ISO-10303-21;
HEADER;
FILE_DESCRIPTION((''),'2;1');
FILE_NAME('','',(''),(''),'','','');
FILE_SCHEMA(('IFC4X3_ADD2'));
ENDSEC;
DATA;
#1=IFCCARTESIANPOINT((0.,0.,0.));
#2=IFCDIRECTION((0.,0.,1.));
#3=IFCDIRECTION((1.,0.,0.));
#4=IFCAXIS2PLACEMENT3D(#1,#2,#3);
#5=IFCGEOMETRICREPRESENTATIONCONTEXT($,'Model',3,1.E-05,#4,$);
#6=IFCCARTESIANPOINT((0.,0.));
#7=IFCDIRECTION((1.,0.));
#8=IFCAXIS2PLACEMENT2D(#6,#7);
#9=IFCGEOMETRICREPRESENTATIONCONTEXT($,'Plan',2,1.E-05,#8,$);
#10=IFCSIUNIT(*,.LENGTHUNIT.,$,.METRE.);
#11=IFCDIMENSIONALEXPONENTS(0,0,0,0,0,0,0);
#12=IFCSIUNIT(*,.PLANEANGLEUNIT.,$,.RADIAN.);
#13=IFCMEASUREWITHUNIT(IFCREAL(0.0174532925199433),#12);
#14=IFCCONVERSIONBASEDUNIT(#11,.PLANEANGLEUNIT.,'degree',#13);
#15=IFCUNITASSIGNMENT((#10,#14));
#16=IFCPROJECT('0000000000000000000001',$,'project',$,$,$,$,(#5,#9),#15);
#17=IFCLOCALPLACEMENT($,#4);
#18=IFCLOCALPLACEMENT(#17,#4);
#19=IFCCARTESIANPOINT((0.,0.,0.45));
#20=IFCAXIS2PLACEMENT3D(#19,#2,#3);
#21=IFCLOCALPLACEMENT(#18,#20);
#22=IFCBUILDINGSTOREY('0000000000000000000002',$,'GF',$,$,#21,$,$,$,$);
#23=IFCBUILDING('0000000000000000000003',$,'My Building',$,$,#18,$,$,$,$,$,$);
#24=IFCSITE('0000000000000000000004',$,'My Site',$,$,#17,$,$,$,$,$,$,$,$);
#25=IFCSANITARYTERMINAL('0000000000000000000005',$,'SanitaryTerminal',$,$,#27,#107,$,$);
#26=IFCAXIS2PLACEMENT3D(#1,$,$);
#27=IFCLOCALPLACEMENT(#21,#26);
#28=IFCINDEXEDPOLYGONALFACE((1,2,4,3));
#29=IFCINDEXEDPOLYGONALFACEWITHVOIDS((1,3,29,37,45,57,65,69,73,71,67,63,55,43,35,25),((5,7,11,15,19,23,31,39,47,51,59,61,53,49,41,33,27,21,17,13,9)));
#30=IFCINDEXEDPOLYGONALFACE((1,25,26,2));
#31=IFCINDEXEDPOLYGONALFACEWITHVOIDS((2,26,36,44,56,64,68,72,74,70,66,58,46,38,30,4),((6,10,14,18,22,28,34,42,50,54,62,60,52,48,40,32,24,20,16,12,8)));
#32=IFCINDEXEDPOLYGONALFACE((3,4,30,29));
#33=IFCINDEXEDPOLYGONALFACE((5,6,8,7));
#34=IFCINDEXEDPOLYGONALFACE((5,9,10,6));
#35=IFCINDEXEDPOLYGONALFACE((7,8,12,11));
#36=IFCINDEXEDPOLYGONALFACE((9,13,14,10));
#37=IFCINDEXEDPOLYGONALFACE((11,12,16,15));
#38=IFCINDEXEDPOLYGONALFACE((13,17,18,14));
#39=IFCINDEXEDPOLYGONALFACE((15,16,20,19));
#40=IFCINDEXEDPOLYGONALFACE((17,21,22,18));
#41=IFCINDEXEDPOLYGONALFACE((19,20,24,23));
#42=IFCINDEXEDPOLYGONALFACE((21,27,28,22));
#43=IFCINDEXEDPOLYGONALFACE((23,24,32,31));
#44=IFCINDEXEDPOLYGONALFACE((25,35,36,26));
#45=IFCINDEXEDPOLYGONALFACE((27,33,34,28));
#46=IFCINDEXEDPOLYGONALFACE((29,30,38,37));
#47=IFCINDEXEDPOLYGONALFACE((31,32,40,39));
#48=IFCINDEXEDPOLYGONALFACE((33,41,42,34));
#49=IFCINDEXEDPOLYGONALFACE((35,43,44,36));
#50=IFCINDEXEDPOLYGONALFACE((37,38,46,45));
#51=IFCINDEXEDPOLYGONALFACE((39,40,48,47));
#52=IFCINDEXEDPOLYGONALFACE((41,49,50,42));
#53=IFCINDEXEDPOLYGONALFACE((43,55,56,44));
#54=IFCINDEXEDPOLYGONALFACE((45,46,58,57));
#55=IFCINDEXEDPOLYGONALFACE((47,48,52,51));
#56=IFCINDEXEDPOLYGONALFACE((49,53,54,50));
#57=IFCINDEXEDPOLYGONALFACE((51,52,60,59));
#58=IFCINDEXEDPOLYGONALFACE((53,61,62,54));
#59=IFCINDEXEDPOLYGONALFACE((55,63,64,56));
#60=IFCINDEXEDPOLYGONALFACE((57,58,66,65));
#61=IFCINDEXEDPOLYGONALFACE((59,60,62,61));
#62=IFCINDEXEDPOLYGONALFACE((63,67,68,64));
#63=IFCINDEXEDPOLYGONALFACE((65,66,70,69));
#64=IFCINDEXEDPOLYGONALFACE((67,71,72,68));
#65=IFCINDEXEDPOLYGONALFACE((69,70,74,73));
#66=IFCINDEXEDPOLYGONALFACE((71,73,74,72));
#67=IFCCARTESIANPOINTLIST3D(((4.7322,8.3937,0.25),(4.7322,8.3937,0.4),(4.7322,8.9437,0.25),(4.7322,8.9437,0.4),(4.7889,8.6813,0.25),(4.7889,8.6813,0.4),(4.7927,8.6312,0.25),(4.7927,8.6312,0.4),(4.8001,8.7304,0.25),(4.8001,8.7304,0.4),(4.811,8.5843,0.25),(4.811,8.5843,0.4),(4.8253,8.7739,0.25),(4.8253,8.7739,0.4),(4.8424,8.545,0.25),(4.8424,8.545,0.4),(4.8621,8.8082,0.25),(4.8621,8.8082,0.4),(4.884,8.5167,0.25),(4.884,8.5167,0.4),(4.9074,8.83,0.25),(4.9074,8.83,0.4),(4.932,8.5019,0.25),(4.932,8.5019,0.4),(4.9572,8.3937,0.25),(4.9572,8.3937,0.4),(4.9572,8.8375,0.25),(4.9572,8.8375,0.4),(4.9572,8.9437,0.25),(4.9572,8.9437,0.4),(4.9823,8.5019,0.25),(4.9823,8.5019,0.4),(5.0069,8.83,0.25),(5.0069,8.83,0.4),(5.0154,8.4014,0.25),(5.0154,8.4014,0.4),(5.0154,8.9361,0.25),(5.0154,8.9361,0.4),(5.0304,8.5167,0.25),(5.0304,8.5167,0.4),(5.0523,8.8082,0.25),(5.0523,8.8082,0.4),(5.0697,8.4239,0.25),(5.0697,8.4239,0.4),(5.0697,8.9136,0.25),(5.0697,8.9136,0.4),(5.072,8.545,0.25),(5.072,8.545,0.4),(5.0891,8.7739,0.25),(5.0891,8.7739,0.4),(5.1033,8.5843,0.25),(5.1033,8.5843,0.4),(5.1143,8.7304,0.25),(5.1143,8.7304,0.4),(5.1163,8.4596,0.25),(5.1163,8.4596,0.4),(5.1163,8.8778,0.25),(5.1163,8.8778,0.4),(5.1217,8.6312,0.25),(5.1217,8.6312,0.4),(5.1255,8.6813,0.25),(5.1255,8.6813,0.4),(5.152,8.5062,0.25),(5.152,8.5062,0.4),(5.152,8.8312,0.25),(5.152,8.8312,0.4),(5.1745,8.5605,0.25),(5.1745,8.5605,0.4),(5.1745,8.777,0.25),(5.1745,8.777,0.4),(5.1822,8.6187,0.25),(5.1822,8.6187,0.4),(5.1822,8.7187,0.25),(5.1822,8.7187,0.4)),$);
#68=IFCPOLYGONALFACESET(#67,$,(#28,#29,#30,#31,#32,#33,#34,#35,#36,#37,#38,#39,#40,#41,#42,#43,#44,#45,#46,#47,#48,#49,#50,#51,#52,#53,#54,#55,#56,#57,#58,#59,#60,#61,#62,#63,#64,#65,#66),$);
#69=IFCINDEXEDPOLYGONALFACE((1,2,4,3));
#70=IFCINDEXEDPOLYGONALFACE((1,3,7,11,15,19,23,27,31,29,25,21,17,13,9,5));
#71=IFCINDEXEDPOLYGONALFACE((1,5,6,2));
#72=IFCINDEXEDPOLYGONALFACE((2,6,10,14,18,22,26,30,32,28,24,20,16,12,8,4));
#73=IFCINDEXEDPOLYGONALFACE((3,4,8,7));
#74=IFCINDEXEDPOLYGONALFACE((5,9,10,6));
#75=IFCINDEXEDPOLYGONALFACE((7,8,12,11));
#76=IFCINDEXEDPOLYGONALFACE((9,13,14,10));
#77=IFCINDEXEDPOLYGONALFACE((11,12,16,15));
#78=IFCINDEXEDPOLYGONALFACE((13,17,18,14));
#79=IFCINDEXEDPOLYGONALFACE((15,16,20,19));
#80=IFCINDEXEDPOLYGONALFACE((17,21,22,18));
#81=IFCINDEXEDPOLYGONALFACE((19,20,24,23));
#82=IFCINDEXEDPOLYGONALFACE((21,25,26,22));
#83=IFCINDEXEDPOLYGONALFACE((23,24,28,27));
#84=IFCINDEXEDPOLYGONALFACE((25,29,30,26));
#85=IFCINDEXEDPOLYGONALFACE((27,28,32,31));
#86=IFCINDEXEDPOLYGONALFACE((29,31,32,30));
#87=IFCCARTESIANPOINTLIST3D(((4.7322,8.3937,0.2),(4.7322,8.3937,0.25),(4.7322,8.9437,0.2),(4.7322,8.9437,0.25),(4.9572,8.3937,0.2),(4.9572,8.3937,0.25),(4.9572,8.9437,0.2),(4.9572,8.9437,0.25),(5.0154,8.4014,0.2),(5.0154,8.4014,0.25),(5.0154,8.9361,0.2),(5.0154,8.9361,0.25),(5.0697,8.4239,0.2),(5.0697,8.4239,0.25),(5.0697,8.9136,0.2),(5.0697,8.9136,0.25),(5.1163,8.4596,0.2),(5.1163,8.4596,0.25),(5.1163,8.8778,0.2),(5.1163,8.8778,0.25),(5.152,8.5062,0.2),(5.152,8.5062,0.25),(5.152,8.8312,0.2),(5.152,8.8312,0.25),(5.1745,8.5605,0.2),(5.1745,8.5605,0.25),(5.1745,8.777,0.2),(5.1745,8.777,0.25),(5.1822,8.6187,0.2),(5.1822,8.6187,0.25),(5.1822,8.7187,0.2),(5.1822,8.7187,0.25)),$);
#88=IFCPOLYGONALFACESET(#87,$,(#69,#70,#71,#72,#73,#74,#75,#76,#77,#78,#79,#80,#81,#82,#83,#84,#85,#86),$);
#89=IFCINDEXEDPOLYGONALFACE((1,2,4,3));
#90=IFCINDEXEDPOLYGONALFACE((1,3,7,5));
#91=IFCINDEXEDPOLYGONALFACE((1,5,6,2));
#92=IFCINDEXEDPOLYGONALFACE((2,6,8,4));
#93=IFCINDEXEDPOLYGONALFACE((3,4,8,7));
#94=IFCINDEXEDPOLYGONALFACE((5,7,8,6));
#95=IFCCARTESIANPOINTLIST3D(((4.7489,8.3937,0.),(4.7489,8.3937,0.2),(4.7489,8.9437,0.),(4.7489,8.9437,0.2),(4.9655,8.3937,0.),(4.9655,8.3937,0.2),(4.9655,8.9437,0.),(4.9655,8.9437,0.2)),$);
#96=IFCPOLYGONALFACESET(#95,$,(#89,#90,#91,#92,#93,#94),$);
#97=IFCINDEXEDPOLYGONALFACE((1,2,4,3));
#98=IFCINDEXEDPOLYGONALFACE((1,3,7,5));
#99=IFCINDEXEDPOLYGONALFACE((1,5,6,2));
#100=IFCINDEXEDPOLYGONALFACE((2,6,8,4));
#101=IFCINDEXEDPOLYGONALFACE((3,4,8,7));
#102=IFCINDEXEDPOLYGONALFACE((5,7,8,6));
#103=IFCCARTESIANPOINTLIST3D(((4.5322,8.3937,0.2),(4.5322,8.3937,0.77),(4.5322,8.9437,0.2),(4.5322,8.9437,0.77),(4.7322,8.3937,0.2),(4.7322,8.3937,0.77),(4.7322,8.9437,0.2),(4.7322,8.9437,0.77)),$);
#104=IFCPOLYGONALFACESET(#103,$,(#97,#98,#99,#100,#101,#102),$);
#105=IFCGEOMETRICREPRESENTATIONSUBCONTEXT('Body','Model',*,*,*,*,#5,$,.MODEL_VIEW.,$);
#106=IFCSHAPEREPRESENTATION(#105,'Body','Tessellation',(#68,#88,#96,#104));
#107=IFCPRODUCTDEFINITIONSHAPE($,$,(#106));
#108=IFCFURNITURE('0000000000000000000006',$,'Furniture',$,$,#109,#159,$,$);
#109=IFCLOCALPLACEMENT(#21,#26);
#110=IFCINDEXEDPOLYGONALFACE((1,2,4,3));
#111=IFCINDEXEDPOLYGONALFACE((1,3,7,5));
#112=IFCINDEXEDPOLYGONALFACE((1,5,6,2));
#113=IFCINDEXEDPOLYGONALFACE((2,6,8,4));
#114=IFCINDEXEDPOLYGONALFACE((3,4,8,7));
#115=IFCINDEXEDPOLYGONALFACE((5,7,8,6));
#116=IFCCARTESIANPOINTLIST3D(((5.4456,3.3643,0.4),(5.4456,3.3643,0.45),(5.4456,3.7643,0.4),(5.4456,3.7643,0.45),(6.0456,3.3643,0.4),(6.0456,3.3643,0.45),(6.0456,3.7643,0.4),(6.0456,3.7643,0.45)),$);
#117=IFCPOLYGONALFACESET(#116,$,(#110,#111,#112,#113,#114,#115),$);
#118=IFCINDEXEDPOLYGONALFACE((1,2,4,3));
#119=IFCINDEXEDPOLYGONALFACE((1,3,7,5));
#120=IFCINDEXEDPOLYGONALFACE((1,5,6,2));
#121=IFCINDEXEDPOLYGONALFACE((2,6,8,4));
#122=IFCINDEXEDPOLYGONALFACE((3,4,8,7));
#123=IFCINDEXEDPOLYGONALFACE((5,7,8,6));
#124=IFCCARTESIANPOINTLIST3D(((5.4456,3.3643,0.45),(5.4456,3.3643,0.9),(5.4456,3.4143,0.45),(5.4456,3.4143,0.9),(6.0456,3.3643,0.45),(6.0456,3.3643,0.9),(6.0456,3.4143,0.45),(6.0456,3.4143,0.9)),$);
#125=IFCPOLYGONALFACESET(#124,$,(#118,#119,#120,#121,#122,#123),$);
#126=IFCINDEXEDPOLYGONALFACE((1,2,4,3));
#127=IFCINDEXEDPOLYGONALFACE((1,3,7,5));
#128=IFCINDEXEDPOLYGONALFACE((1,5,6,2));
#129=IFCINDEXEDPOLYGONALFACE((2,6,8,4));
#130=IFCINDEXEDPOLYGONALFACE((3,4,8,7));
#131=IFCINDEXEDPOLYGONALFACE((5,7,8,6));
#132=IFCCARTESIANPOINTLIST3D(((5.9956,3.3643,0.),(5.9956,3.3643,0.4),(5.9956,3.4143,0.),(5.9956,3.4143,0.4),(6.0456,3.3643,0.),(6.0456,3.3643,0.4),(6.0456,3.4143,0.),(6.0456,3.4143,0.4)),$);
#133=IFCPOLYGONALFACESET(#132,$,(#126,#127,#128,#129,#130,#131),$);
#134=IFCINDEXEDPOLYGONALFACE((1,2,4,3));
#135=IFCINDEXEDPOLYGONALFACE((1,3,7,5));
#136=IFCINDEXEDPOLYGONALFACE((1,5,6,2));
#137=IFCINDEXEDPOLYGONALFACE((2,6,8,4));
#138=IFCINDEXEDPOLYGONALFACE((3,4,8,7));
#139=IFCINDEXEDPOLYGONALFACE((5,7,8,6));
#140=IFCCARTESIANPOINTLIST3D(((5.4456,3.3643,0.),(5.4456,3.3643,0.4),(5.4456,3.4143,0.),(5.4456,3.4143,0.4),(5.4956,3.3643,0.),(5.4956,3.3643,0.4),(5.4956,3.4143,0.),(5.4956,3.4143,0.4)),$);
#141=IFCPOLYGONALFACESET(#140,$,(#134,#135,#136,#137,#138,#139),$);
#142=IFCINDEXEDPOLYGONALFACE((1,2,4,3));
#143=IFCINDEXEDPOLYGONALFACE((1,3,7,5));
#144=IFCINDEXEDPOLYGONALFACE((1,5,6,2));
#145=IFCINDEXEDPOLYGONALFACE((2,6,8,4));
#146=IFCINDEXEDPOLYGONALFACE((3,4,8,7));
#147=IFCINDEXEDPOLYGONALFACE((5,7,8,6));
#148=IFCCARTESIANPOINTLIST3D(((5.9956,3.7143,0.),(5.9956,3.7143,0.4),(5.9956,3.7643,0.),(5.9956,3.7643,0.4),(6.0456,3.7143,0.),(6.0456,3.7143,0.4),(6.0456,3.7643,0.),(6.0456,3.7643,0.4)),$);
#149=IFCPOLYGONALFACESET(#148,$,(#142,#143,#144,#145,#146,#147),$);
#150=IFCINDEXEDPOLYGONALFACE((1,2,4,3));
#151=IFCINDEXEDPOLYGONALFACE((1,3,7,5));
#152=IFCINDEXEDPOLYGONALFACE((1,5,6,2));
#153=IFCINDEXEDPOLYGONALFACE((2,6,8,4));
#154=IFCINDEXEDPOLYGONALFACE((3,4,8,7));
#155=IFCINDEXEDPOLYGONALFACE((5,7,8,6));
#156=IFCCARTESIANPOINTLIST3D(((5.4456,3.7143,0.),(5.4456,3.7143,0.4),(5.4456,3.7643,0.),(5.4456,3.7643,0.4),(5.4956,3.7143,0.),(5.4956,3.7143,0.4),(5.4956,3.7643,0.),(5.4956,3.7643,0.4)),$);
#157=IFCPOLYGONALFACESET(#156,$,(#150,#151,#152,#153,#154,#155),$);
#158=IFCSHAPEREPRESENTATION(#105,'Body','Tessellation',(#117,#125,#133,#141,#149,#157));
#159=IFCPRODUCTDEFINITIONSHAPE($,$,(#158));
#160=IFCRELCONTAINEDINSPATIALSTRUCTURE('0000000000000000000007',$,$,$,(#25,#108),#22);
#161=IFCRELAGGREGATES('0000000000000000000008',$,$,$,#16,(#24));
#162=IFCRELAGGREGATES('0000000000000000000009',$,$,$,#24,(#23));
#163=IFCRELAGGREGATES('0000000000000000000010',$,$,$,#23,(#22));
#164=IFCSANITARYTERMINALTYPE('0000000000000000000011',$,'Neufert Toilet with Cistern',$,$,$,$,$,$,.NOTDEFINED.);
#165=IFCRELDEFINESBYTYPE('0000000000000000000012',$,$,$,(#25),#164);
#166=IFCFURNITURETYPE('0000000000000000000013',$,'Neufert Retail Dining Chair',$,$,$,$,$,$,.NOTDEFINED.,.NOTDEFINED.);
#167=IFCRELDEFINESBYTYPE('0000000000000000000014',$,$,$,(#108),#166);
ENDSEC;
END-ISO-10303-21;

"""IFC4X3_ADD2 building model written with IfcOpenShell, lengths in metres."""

from ifc_helpers import new_model, entity, si_unit, converted_unit, frame, frame_2d, origin_with_axes, origin_2d_with_axis, place, context, subcontext, project, spatial, line, arc, indexed_curve, circle_curve, outline, extrude, shape, source, transform, mapped, type_object, type_shapes, element, save


model = new_model("IFC4X3_ADD2")

# Units and contexts
model_context = context("Model", 3, precision=1e-05, world=origin_with_axes())
plan_context = context("Plan", 2, precision=1e-05, world=origin_2d_with_axis())
body_context_1 = subcontext(model_context, "Body", "Model", "MODEL_VIEW")
body_context_2 = subcontext(plan_context, "Body", "Plan", "PLAN_VIEW")
ifc_project = project(units=[si_unit("LENGTHUNIT", "METRE"), converted_unit("PLANEANGLEUNIT", "degree", entity("IfcReal", 0.0174532925199433), si_unit("PLANEANGLEUNIT", "RADIAN"), dimensions=[0, 0, 0, 0, 0, 0, 0])], contexts=[model_context, plan_context])

# Site, building, storey
site_placement = place(None, origin_with_axes())
site = spatial("IfcSite", under=ifc_project, at=site_placement, Name="My Site")
building_placement = place(site_placement, origin_with_axes())
building = spatial("IfcBuilding", under=site, at=building_placement, Name="My Building")
storey_placement = place(building_placement, frame((0.0, 0.0, 0.45), z_axis=(0.0, 0.0, 1.0), x_axis=(1.0, 0.0, 0.0)))
storey = spatial("IfcBuildingStorey", under=building, at=storey_placement, Name="GF")

# Sanitary terminal
sanitary_terminal_type_1 = type_object("IfcSanitaryTerminalType", Name="Neufert Toilet with Cistern", PredefinedType="NOTDEFINED")
shared_shape_1 = source(origin_with_axes(), body_context_1, "Body", "SweptSolid", [
    extrude(outline(indexed_curve([(-0.275, -0.2), (0.275, -0.2), (0.275, -0.425), (0.2091, -0.5841), (0.05, -0.65), (-0.05, -0.65), (-0.2091, -0.5841), (-0.275, -0.425), (0.0, -0.5938), (0.0, -0.2563)], segments=[arc(8, 7, 6), line(6, 5), arc(5, 4, 3), line(3, 2), line(2, 1), line(1, 8)], self_intersect=False), holes=[circle_curve(frame_2d((0.0, -0.425)), 0.1687)]), frame((0.0, 0.0, 0.25), z_axis=(0.0, 0.0, 1.0), x_axis=(1.0, 0.0, 0.0)), (0.0, 0.0, 1.0), 0.15),
    extrude(outline(indexed_curve([(-0.275, -0.2), (0.275, -0.2), (0.275, -0.425), (0.2091, -0.5841), (0.05, -0.65), (-0.05, -0.65), (-0.2091, -0.5841), (-0.275, -0.425)], segments=[line(1, 2), line(2, 3), arc(3, 4, 5), line(5, 6), arc(6, 7, 8), line(8, 1)])), frame((0.0, 0.0, 0.2), z_axis=(0.0, 0.0, 1.0), x_axis=(1.0, 0.0, 0.0)), (0.0, 0.0, 1.0), 0.05),
    extrude(outline(indexed_curve([(-0.275, -0.2167), (0.275, -0.2167), (0.275, -0.4333), (-0.275, -0.4333)], segments=[line(1, 2, 3, 4, 1)])), origin_with_axes(), (0.0, 0.0, 1.0), 0.2),
    extrude(outline(indexed_curve([(-0.275, 0.0), (0.275, 0.0), (0.275, -0.2), (-0.275, -0.2)], segments=[line(1, 2, 3, 4, 1)])), frame((0.0, 0.0, 0.2), z_axis=(0.0, 0.0, 1.0), x_axis=(1.0, 0.0, 0.0)), (0.0, 0.0, 1.0), 0.57),
])
shared_shape_2 = source(origin_with_axes(), body_context_2, "Body", "Curve2D", [
    entity("IfcIndexedPolyCurve", entity("IfcCartesianPointList2D", [[-0.275, 0.0], [0.275, 0.0], [0.275, -0.2], [-0.275, -0.2]]), [entity("IfcLineIndex", [1, 2, 3, 4, 1])]),
    entity("IfcIndexedPolyCurve", entity("IfcCartesianPointList2D", [[0.165, -0.2], [0.1925, -0.335]])),
    entity("IfcTrimmedCurve", entity("IfcEllipse", entity("IfcAxis2Placement2D", entity("IfcCartesianPoint", [0.0, -0.335]), entity("IfcDirection", [1.0, 0.0])), 0.1925, 0.315), [entity("IfcCartesianPoint", [-0.1925, -0.335])], [entity("IfcCartesianPoint", [0.1925, -0.335])], True, "CARTESIAN"),
    entity("IfcIndexedPolyCurve", entity("IfcCartesianPointList2D", [[-0.165, -0.2], [-0.1925, -0.335]])),
    entity("IfcEllipse", entity("IfcAxis2Placement2D", entity("IfcCartesianPoint", [0.0, -0.452]), entity("IfcDirection", [1.0, 0.0])), 0.1313, 0.1575),
    entity("IfcIndexedPolyCurve", entity("IfcCartesianPointList2D", [[-0.0344, -0.452], [-0.0344, -0.4295], [0.0344, -0.4295], [0.0344, -0.452]])),
    entity("IfcTrimmedCurve", entity("IfcEllipse", entity("IfcAxis2Placement2D", entity("IfcCartesianPoint", [0.0, -0.452]), entity("IfcDirection", [1.0, 0.0])), 0.0344, 0.0225), [entity("IfcCartesianPoint", [-0.0344, -0.452])], [entity("IfcCartesianPoint", [0.0344, -0.452])], True, "CARTESIAN"),
])
type_shapes(sanitary_terminal_type_1, [shared_shape_1, shared_shape_2])
sanitary_terminal_1_placement = place(storey_placement, frame((4.5322, 8.6687, 0.0), z_axis=(0.0, 0.0, 1.0), x_axis=(0.0, 1.0, 0.0)))
element("IfcSanitaryTerminal", 1, at=sanitary_terminal_1_placement, inside=storey, type_object=sanitary_terminal_type_1, Name="SanitaryTerminal", shapes=[
    shape(body_context_1, "Body", "MappedRepresentation", [mapped(shared_shape_1, transform((0.0, 0.0, 0.0), x_axis=(1.0, 0.0, 0.0), y_axis=(0.0, 1.0, 0.0), z_axis=(0.0, 0.0, 1.0), scale=1.0))]),
    shape(body_context_2, "Body", "MappedRepresentation", [mapped(shared_shape_2, transform((0.0, 0.0, 0.0), x_axis=(1.0, 0.0, 0.0), y_axis=(0.0, 1.0, 0.0), z_axis=(0.0, 0.0, 1.0), scale=1.0))]),
])

# Furniture
furniture_type_1 = type_object("IfcFurnitureType", Name="Neufert Retail Dining Chair", AssemblyPlace="NOTDEFINED", PredefinedType="NOTDEFINED")
shared_shape_3 = source(origin_with_axes(), body_context_1, "Body", "SweptSolid", [
    extrude(outline(indexed_curve([(-0.3, 0.0), (0.3, 0.0), (0.3, -0.4), (-0.3, -0.4)], segments=[line(1, 2, 3, 4, 1)])), frame((0.0, 0.0, 0.45), z_axis=(0.0, 0.0, 1.0), x_axis=(1.0, 0.0, 0.0)), (0.0, 0.0, -1.0), 0.05),
    extrude(outline(indexed_curve([(-0.3, 0.0), (0.3, 0.0), (0.3, -0.05), (-0.3, -0.05)], segments=[line(1, 2, 3, 4, 1)])), frame((0.0, 0.0, 0.9), z_axis=(0.0, 0.0, 1.0), x_axis=(1.0, 0.0, 0.0)), (0.0, 0.0, -1.0), 0.45),
    extrude(outline(indexed_curve([(-0.3, 0.0), (-0.25, 0.0), (-0.25, -0.05), (-0.3, -0.05)], segments=[line(1, 2, 3, 4, 1)])), origin_with_axes(), (0.0, 0.0, 1.0), 0.4),
    extrude(outline(indexed_curve([(0.3, 0.0), (0.25, 0.0), (0.25, -0.05), (0.3, -0.05)], segments=[line(1, 2, 3, 4, 1)])), origin_with_axes(), (0.0, 0.0, 1.0), 0.4),
    extrude(outline(indexed_curve([(-0.3, -0.4), (-0.25, -0.4), (-0.25, -0.35), (-0.3, -0.35)], segments=[line(1, 2, 3, 4, 1)])), origin_with_axes(), (0.0, 0.0, 1.0), 0.4),
    extrude(outline(indexed_curve([(0.3, -0.4), (0.25, -0.4), (0.25, -0.35), (0.3, -0.35)], segments=[line(1, 2, 3, 4, 1)])), origin_with_axes(), (0.0, 0.0, 1.0), 0.4),
])
shared_shape_4 = source(origin_with_axes(), body_context_2, "Body", "Curve2D", [
    entity("IfcIndexedPolyCurve", entity("IfcCartesianPointList2D", [[-0.3, -0.4], [0.3, -0.4]])),
    entity("IfcIndexedPolyCurve", entity("IfcCartesianPointList2D", [[-0.3, -0.4], [-0.3, -0.3], [-0.2121, -0.0879], [0.0, 0.0], [0.2121, -0.0879], [0.3, -0.3], [0.3, -0.4]]), [entity("IfcLineIndex", [1, 2]), entity("IfcArcIndex", [2, 3, 4]), entity("IfcArcIndex", [4, 5, 6]), entity("IfcLineIndex", [6, 7])]),
    entity("IfcIndexedPolyCurve", entity("IfcCartesianPointList2D", [[-0.26, -0.4], [-0.26, -0.3], [-0.1838, -0.1162], [0.0, -0.04], [0.1838, -0.1162], [0.26, -0.3], [0.26, -0.4]]), [entity("IfcLineIndex", [1, 2]), entity("IfcArcIndex", [2, 3, 4]), entity("IfcArcIndex", [4, 5, 6]), entity("IfcLineIndex", [6, 7])]),
])
type_shapes(furniture_type_1, [shared_shape_3, shared_shape_4])
for number, where, z_axis, x_axis, name in (
    (2, (5.7456, 3.3643, 0.0), (0.0, 0.0, 1.0), (-1.0, 0.000001, 0.0), "Furniture"),
):
    element("IfcFurniture", number, at=place(storey_placement, frame(where, z_axis=z_axis, x_axis=x_axis)), inside=storey, type_object=furniture_type_1, Name=name, shapes=[
        shape(body_context_1, "Body", "MappedRepresentation", [mapped(shared_shape_3, transform((0.0, 0.0, 0.0), x_axis=(1.0, 0.0, 0.0), y_axis=(0.0, 1.0, 0.0), z_axis=(0.0, 0.0, 1.0), scale=1.0))]),
        shape(body_context_2, "Body", "MappedRepresentation", [mapped(shared_shape_4, transform((0.0, 0.0, 0.0), x_axis=(1.0, 0.0, 0.0), y_axis=(0.0, 1.0, 0.0), z_axis=(0.0, 0.0, 1.0), scale=1.0))]),
    ])

save(model, "model.ifc")
